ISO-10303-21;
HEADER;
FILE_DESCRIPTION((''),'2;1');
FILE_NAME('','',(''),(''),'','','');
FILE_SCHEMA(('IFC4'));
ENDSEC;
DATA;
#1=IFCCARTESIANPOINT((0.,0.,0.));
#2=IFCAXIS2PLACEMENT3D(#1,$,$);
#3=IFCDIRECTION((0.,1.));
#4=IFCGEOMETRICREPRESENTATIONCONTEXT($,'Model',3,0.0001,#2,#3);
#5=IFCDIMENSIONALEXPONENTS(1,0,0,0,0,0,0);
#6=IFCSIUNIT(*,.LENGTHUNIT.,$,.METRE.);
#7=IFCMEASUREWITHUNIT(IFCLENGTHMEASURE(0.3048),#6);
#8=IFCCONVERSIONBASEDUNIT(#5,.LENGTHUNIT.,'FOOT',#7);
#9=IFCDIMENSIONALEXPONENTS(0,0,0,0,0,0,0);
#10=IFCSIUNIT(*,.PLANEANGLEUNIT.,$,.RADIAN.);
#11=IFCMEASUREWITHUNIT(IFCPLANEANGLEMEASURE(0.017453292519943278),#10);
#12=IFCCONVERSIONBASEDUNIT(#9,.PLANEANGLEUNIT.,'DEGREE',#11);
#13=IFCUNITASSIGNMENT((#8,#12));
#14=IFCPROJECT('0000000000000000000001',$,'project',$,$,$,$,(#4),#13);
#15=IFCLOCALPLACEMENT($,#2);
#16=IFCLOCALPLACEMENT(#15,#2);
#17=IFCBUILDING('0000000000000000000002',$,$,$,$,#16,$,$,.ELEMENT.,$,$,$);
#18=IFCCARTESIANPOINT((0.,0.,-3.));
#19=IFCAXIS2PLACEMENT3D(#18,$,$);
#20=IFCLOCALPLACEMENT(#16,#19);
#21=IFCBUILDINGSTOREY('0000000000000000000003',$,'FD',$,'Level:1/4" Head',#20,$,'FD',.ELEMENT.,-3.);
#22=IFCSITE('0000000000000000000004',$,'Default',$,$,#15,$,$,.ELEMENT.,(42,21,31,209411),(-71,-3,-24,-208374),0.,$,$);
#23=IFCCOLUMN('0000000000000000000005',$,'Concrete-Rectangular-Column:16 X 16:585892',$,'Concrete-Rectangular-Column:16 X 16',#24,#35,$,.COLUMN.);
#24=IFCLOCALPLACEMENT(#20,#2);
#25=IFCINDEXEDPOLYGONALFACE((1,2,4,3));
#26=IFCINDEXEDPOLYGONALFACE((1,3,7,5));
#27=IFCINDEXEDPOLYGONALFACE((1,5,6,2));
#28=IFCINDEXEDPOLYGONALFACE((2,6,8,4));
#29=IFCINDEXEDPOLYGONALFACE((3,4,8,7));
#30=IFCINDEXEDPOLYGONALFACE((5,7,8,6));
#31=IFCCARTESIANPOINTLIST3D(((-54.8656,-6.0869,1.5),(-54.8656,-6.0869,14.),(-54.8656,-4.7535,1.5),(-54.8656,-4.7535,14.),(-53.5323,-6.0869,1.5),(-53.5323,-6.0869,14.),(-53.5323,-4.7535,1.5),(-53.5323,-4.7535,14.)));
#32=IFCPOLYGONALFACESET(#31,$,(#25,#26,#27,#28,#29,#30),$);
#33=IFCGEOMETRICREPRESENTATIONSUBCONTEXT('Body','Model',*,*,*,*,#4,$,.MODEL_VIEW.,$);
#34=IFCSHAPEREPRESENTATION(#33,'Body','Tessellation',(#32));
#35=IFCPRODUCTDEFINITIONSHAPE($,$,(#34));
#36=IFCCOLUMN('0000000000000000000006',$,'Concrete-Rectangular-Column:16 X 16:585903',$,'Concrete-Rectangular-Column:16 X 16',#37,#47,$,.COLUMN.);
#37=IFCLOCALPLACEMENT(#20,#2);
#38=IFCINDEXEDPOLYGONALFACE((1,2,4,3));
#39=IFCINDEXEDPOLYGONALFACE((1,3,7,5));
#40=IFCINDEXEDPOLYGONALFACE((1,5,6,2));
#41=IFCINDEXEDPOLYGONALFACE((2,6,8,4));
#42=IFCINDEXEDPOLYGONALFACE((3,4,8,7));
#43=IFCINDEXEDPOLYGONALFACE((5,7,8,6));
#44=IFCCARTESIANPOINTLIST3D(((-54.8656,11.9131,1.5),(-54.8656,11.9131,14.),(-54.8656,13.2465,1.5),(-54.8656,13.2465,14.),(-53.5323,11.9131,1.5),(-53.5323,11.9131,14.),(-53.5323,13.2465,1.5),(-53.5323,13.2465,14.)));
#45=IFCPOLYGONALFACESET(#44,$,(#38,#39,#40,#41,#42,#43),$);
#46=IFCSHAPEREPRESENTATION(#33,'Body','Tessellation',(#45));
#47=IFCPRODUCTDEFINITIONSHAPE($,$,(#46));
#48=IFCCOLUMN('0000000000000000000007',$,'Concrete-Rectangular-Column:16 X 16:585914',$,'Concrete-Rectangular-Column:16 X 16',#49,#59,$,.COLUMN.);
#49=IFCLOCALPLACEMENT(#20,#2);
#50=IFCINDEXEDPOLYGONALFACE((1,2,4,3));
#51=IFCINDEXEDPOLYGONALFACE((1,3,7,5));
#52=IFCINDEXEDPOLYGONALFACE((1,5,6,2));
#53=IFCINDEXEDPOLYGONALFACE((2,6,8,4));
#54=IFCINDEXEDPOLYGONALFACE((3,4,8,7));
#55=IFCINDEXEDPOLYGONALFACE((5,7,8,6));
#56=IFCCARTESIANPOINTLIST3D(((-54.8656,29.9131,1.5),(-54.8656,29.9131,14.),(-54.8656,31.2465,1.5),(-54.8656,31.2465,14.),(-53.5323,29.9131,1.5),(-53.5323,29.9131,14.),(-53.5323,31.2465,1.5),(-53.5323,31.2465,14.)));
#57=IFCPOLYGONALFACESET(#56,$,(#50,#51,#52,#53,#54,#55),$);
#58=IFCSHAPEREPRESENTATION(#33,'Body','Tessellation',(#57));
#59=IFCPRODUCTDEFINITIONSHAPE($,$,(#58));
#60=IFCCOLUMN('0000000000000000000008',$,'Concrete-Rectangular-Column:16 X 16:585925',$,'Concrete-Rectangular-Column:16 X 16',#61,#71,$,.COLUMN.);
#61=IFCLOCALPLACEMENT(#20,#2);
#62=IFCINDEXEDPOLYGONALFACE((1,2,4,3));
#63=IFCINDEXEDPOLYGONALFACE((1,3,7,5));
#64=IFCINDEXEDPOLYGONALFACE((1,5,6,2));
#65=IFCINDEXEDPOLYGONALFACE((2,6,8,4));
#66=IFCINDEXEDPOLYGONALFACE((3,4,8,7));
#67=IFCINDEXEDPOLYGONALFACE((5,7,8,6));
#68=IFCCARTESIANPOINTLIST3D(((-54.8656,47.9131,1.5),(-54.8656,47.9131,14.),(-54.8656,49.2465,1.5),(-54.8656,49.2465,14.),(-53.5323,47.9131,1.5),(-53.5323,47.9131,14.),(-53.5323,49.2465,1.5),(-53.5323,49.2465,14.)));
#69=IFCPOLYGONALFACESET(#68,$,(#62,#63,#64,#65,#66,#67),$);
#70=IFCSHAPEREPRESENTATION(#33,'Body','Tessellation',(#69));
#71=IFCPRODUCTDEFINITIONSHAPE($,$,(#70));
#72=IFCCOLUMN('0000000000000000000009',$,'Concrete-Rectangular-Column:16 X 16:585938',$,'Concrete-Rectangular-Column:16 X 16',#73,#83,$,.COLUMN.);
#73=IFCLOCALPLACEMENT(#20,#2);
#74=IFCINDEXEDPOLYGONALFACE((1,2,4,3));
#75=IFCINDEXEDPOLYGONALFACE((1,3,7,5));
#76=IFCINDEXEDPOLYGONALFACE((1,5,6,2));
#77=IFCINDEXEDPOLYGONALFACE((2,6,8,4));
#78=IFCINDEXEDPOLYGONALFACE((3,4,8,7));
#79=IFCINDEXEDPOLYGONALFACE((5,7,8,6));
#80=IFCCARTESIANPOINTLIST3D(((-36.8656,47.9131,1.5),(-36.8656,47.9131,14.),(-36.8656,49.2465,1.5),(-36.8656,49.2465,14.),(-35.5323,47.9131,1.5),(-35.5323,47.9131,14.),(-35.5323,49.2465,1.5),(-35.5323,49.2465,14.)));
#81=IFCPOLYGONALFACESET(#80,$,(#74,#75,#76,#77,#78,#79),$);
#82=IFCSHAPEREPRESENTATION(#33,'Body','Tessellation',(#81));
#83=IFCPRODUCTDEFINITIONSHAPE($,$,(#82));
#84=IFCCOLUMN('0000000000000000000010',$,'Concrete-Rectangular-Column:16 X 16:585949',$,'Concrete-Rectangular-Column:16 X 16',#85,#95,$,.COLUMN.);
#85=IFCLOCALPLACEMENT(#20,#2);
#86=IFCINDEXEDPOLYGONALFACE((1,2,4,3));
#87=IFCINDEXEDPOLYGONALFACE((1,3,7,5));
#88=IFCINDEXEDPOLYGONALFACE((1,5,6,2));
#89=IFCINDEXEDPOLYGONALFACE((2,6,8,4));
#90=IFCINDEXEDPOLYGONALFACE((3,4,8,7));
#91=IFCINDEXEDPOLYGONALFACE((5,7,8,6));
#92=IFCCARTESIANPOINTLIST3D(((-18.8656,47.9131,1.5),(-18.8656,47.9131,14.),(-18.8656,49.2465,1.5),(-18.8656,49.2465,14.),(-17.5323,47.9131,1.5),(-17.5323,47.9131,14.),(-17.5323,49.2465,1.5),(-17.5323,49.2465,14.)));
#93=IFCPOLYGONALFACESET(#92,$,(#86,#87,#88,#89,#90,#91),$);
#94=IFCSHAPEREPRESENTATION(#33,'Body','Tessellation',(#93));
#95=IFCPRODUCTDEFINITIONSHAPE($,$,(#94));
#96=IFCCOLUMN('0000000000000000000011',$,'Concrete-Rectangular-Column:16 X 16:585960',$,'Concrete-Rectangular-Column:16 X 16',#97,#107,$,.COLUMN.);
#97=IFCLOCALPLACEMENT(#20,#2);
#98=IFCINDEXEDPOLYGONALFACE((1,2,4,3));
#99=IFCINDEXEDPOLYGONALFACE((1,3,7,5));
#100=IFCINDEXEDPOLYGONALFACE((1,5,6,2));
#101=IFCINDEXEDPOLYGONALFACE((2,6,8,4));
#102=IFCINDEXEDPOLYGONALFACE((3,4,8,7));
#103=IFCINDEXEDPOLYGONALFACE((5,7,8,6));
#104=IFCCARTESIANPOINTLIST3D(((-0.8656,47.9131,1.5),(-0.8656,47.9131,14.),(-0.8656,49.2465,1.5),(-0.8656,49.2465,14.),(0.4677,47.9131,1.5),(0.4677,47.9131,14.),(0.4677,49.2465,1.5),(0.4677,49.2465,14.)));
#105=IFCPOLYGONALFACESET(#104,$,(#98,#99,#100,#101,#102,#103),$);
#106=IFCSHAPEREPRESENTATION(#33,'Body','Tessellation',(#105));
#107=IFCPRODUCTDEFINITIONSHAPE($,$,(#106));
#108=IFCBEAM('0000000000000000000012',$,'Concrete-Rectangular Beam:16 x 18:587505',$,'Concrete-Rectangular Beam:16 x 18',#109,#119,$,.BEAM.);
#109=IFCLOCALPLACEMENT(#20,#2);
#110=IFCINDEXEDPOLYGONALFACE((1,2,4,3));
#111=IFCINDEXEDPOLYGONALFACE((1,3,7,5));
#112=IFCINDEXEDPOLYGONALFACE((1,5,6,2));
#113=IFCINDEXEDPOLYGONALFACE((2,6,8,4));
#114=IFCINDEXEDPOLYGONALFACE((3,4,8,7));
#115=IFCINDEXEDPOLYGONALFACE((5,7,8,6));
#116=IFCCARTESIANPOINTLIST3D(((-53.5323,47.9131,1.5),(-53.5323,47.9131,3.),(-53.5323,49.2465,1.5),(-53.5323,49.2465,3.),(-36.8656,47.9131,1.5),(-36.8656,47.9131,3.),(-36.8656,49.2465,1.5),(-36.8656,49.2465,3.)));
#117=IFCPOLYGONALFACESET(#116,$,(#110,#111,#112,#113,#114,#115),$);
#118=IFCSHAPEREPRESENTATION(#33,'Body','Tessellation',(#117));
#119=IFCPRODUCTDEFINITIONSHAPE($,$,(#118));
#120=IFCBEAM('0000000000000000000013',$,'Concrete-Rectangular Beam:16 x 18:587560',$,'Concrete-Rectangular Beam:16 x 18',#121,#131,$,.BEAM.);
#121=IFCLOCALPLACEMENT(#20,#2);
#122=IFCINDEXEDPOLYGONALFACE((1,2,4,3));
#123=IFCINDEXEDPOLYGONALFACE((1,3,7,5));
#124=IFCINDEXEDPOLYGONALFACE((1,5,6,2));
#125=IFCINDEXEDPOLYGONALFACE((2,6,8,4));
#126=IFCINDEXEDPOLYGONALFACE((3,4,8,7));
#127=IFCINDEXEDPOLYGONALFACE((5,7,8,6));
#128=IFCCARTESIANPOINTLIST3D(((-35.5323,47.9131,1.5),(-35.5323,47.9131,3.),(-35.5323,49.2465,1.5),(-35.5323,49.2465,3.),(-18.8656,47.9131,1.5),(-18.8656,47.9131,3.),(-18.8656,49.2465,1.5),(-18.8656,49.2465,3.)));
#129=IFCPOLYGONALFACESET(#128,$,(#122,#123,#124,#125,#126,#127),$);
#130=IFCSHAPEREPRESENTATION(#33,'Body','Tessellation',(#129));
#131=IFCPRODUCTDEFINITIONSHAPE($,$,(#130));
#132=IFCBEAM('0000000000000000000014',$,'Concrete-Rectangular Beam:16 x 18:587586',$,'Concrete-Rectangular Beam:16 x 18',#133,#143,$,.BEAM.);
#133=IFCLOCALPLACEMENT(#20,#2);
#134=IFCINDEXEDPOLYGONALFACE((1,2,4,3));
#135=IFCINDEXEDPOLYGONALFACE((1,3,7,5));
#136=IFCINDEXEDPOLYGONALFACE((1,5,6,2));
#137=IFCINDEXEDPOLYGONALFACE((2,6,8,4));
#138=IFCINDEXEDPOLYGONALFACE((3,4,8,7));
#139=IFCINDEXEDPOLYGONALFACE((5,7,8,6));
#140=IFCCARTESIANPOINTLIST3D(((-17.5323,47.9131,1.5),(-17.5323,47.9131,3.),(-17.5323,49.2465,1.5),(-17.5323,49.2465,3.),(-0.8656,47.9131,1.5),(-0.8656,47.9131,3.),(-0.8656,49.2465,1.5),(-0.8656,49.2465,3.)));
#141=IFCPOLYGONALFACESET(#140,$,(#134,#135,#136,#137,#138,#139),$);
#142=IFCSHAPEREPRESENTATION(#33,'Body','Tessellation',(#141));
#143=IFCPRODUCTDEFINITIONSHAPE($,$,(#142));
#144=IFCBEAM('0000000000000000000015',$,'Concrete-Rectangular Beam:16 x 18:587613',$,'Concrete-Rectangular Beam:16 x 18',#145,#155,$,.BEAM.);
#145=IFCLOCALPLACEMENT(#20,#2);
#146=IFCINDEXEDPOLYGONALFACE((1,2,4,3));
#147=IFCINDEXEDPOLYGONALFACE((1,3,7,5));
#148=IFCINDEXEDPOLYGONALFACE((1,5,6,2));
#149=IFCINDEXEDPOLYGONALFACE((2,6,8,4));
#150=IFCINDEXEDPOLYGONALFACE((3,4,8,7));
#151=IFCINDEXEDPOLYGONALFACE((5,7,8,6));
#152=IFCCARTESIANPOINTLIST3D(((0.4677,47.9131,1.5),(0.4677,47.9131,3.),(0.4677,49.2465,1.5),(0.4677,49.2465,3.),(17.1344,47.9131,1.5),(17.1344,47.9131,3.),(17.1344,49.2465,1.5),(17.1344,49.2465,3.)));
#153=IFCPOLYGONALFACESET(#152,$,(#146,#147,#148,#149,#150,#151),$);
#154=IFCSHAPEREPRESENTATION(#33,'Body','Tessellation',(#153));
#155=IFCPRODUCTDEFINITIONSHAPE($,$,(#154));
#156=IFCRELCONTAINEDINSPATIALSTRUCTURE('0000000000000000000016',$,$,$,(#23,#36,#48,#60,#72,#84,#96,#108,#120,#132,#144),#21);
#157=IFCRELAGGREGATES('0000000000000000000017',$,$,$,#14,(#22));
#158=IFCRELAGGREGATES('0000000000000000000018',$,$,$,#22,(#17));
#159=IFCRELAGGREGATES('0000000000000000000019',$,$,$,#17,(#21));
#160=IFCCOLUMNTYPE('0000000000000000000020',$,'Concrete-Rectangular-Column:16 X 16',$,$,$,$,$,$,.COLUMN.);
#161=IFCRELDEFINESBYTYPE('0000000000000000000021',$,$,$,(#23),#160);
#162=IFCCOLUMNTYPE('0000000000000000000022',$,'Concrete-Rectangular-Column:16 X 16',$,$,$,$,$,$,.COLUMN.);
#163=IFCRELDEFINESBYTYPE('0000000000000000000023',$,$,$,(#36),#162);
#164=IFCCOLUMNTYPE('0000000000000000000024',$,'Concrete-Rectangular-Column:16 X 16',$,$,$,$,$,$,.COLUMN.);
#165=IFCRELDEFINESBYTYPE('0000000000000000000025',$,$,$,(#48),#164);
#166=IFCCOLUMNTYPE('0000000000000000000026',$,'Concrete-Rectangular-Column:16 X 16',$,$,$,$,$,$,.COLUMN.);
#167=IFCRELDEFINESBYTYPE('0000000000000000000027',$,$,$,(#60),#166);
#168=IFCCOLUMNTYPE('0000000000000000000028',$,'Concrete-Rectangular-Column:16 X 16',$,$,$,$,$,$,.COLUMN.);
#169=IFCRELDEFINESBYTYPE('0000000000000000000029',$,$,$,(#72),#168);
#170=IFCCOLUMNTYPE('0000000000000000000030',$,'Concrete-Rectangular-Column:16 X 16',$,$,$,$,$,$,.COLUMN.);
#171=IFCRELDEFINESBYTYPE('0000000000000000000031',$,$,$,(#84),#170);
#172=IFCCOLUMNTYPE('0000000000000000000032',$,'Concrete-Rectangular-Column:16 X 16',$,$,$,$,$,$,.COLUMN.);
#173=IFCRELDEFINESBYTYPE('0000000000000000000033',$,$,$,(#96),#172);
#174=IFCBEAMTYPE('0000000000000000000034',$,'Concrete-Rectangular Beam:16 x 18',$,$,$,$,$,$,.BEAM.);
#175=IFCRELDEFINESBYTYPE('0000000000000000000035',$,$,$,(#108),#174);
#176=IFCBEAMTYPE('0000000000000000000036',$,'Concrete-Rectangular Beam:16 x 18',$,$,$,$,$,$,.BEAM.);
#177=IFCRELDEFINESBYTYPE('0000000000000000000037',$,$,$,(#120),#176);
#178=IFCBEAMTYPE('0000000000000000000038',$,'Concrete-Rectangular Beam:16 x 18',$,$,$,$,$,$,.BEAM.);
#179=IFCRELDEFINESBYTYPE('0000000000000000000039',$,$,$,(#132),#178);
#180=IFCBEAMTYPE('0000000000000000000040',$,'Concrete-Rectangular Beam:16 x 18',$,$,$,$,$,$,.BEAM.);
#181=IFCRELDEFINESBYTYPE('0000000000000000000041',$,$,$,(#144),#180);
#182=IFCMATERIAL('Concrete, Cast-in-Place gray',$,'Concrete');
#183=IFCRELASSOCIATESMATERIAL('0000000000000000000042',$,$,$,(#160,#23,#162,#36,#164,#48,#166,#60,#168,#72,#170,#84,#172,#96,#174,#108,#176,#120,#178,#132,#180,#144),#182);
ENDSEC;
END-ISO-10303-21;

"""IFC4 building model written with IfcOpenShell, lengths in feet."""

from ifc_helpers import new_model, entity, si_unit, converted_unit, direction, frame, origin, place, context, subcontext, project, spatial, indexed_curve, outline, extrude, source, transform, mapped, material, type_object, type_shapes, element, save


model = new_model("IFC4")

# Units and contexts
model_context = context("Model", 3, precision=0.0001, world=origin(), true_north=direction((0.0, 1.0)))
body_context = subcontext(model_context, "Body", "Model", "MODEL_VIEW")
ifc_project = project(units=[converted_unit("LENGTHUNIT", "FOOT", entity("IfcLengthMeasure", 0.3048), si_unit("LENGTHUNIT", "METRE"), dimensions=[1, 0, 0, 0, 0, 0, 0]), converted_unit("PLANEANGLEUNIT", "DEGREE", entity("IfcPlaneAngleMeasure", 0.017453292519943278), si_unit("PLANEANGLEUNIT", "RADIAN"), dimensions=[0, 0, 0, 0, 0, 0, 0])], contexts=[model_context])

# Site, building, storey
site_placement = place(None, origin())
site = spatial("IfcSite", under=ifc_project, at=site_placement, Name="Default", CompositionType="ELEMENT", RefLatitude=(42, 21, 31, 209411), RefLongitude=(-71, -3, -24, -208374), RefElevation=0.0)
building_placement = place(site_placement, origin())
building = spatial("IfcBuilding", under=site, at=building_placement, CompositionType="ELEMENT")
storey_placement = place(building_placement, frame((0.0, 0.0, -3.0)))
storey = spatial("IfcBuildingStorey", under=building, at=storey_placement, Name="FD", ObjectType="Level:1/4\" Head", LongName="FD", CompositionType="ELEMENT", Elevation=-3.0)

# Columns
ifc_material = material(Name="Concrete, Cast-in-Place gray", Category="Concrete")
column_type_1 = type_object("IfcColumnType", Name="Concrete-Rectangular-Column:16 X 16", PredefinedType="COLUMN", material=ifc_material)
shared_shape_1 = source(origin(), body_context, "Body", "SweptSolid", [
    extrude(outline(indexed_curve([(-6.25, -0.6667), (6.25, -0.6667), (6.25, 0.6667), (-6.25, 0.6667), (-6.25, -0.6667)], self_intersect=False)), frame((-54.8656, -5.4202, 4.75), z_axis=(1.0, 0.0, 0.0), x_axis=(0.0, 0.0, 1.0)), (0.0, 0.0, 1.0), 1.3333),
])
type_shapes(column_type_1, [shared_shape_1])
column_1_placement = place(storey_placement, frame((0.0, 0.0, 3.0)))
element("IfcColumn", 1, at=column_1_placement, inside=storey, type_object=column_type_1, material=ifc_material, Name="Concrete-Rectangular-Column:16 X 16:585892", ObjectType="Concrete-Rectangular-Column:16 X 16", PredefinedType="COLUMN", context=body_context, shape_type="MappedRepresentation", body=[
    mapped(shared_shape_1, transform((0.0, 0.0, 0.0), scale=1.0)),
])
column_type_2 = type_object("IfcColumnType", Name="Concrete-Rectangular-Column:16 X 16", PredefinedType="COLUMN", material=ifc_material)
shared_shape_2 = source(origin(), body_context, "Body", "SweptSolid", [
    extrude(outline(indexed_curve([(-6.25, -0.6667), (6.25, -0.6667), (6.25, 0.6667), (-6.25, 0.6667), (-6.25, -0.6667)], self_intersect=False)), frame((-54.8656, 12.5798, 4.75), z_axis=(1.0, 0.0, 0.0), x_axis=(0.0, 0.0, 1.0)), (0.0, 0.0, 1.0), 1.3333),
])
type_shapes(column_type_2, [shared_shape_2])
column_2_placement = place(storey_placement, frame((0.0, 0.0, 3.0)))
element("IfcColumn", 2, at=column_2_placement, inside=storey, type_object=column_type_2, material=ifc_material, Name="Concrete-Rectangular-Column:16 X 16:585903", ObjectType="Concrete-Rectangular-Column:16 X 16", PredefinedType="COLUMN", context=body_context, shape_type="MappedRepresentation", body=[
    mapped(shared_shape_2, transform((0.0, 0.0, 0.0), scale=1.0)),
])
column_type_3 = type_object("IfcColumnType", Name="Concrete-Rectangular-Column:16 X 16", PredefinedType="COLUMN", material=ifc_material)
shared_shape_3 = source(origin(), body_context, "Body", "SweptSolid", [
    extrude(outline(indexed_curve([(-6.25, -0.6667), (6.25, -0.6667), (6.25, 0.6667), (-6.25, 0.6667), (-6.25, -0.6667)], self_intersect=False)), frame((-54.8656, 30.5798, 4.75), z_axis=(1.0, 0.0, 0.0), x_axis=(0.0, 0.0, 1.0)), (0.0, 0.0, 1.0), 1.3333),
])
type_shapes(column_type_3, [shared_shape_3])
column_3_placement = place(storey_placement, frame((0.0, 0.0, 3.0)))
element("IfcColumn", 3, at=column_3_placement, inside=storey, type_object=column_type_3, material=ifc_material, Name="Concrete-Rectangular-Column:16 X 16:585914", ObjectType="Concrete-Rectangular-Column:16 X 16", PredefinedType="COLUMN", context=body_context, shape_type="MappedRepresentation", body=[
    mapped(shared_shape_3, transform((0.0, 0.0, 0.0), scale=1.0)),
])
column_type_4 = type_object("IfcColumnType", Name="Concrete-Rectangular-Column:16 X 16", PredefinedType="COLUMN", material=ifc_material)
shared_shape_4 = source(origin(), body_context, "Body", "SweptSolid", [
    extrude(outline(indexed_curve([(-6.25, -0.6667), (6.25, -0.6667), (6.25, 0.6667), (-6.25, 0.6667), (-6.25, -0.6667)], self_intersect=False)), frame((-54.8656, 48.5798, 4.75), z_axis=(1.0, 0.0, 0.0), x_axis=(0.0, 0.0, 1.0)), (0.0, 0.0, 1.0), 1.3333),
])
type_shapes(column_type_4, [shared_shape_4])
column_4_placement = place(storey_placement, frame((0.0, 0.0, 3.0)))
element("IfcColumn", 4, at=column_4_placement, inside=storey, type_object=column_type_4, material=ifc_material, Name="Concrete-Rectangular-Column:16 X 16:585925", ObjectType="Concrete-Rectangular-Column:16 X 16", PredefinedType="COLUMN", context=body_context, shape_type="MappedRepresentation", body=[
    mapped(shared_shape_4, transform((0.0, 0.0, 0.0), scale=1.0)),
])
column_type_5 = type_object("IfcColumnType", Name="Concrete-Rectangular-Column:16 X 16", PredefinedType="COLUMN", material=ifc_material)
shared_shape_5 = source(origin(), body_context, "Body", "SweptSolid", [
    extrude(outline(indexed_curve([(-6.25, -0.6667), (6.25, -0.6667), (6.25, 0.6667), (-6.25, 0.6667), (-6.25, -0.6667)], self_intersect=False)), frame((-36.8656, 48.5798, 4.75), z_axis=(1.0, 0.0, 0.0), x_axis=(0.0, 0.0, 1.0)), (0.0, 0.0, 1.0), 1.3333),
])
type_shapes(column_type_5, [shared_shape_5])
column_5_placement = place(storey_placement, frame((0.0, 0.0, 3.0)))
element("IfcColumn", 5, at=column_5_placement, inside=storey, type_object=column_type_5, material=ifc_material, Name="Concrete-Rectangular-Column:16 X 16:585938", ObjectType="Concrete-Rectangular-Column:16 X 16", PredefinedType="COLUMN", context=body_context, shape_type="MappedRepresentation", body=[
    mapped(shared_shape_5, transform((0.0, 0.0, 0.0), scale=1.0)),
])
column_type_6 = type_object("IfcColumnType", Name="Concrete-Rectangular-Column:16 X 16", PredefinedType="COLUMN", material=ifc_material)
shared_shape_6 = source(origin(), body_context, "Body", "SweptSolid", [
    extrude(outline(indexed_curve([(-6.25, -0.6667), (6.25, -0.6667), (6.25, 0.6667), (-6.25, 0.6667), (-6.25, -0.6667)], self_intersect=False)), frame((-18.8656, 48.5798, 4.75), z_axis=(1.0, 0.0, 0.0), x_axis=(0.0, 0.0, 1.0)), (0.0, 0.0, 1.0), 1.3333),
])
type_shapes(column_type_6, [shared_shape_6])
column_6_placement = place(storey_placement, frame((0.0, 0.0, 3.0)))
element("IfcColumn", 6, at=column_6_placement, inside=storey, type_object=column_type_6, material=ifc_material, Name="Concrete-Rectangular-Column:16 X 16:585949", ObjectType="Concrete-Rectangular-Column:16 X 16", PredefinedType="COLUMN", context=body_context, shape_type="MappedRepresentation", body=[
    mapped(shared_shape_6, transform((0.0, 0.0, 0.0), scale=1.0)),
])
column_type_7 = type_object("IfcColumnType", Name="Concrete-Rectangular-Column:16 X 16", PredefinedType="COLUMN", material=ifc_material)
shared_shape_7 = source(origin(), body_context, "Body", "SweptSolid", [
    extrude(outline(indexed_curve([(-6.25, -0.6667), (6.25, -0.6667), (6.25, 0.6667), (-6.25, 0.6667), (-6.25, -0.6667)], self_intersect=False)), frame((-0.8656, 48.5798, 4.75), z_axis=(1.0, 0.0, 0.0), x_axis=(0.0, 0.0, 1.0)), (0.0, 0.0, 1.0), 1.3333),
])
type_shapes(column_type_7, [shared_shape_7])
column_7_placement = place(storey_placement, frame((0.0, 0.0, 3.0)))
element("IfcColumn", 7, at=column_7_placement, inside=storey, type_object=column_type_7, material=ifc_material, Name="Concrete-Rectangular-Column:16 X 16:585960", ObjectType="Concrete-Rectangular-Column:16 X 16", PredefinedType="COLUMN", context=body_context, shape_type="MappedRepresentation", body=[
    mapped(shared_shape_7, transform((0.0, 0.0, 0.0), scale=1.0)),
])

# Beams
beam_type_1 = type_object("IfcBeamType", Name="Concrete-Rectangular Beam:16 x 18", PredefinedType="BEAM", material=ifc_material)
shared_shape_8 = source(origin(), body_context, "Body", "SweptSolid", [
    extrude(outline(indexed_curve([(-0.75, -0.6667), (0.75, -0.6667), (0.75, 0.6667), (-0.75, 0.6667), (-0.75, -0.6667)], self_intersect=False)), frame((-53.5323, 48.5798, -0.75), z_axis=(1.0, 0.0, 0.0), x_axis=(0.0, 0.0, -1.0)), (0.0, 0.0, 1.0), 16.6667),
])
type_shapes(beam_type_1, [shared_shape_8])
beam_1_placement = place(storey_placement, frame((0.0, 0.0, 3.0)))
element("IfcBeam", 8, at=beam_1_placement, inside=storey, type_object=beam_type_1, material=ifc_material, Name="Concrete-Rectangular Beam:16 x 18:587505", ObjectType="Concrete-Rectangular Beam:16 x 18", PredefinedType="BEAM", context=body_context, shape_type="MappedRepresentation", body=[
    mapped(shared_shape_8, transform((0.0, 0.0, 0.0), scale=1.0)),
])
beam_type_2 = type_object("IfcBeamType", Name="Concrete-Rectangular Beam:16 x 18", PredefinedType="BEAM", material=ifc_material)
shared_shape_9 = source(origin(), body_context, "Body", "SweptSolid", [
    extrude(outline(indexed_curve([(-0.75, -0.6667), (0.75, -0.6667), (0.75, 0.6667), (-0.75, 0.6667), (-0.75, -0.6667)], self_intersect=False)), frame((-18.8656, 48.5798, -0.75), z_axis=(-1.0, 0.0, 0.0), x_axis=(0.0, 0.0, -1.0)), (0.0, 0.0, 1.0), 16.6667),
])
type_shapes(beam_type_2, [shared_shape_9])
beam_2_placement = place(storey_placement, frame((0.0, 0.0, 3.0)))
element("IfcBeam", 9, at=beam_2_placement, inside=storey, type_object=beam_type_2, material=ifc_material, Name="Concrete-Rectangular Beam:16 x 18:587560", ObjectType="Concrete-Rectangular Beam:16 x 18", PredefinedType="BEAM", context=body_context, shape_type="MappedRepresentation", body=[
    mapped(shared_shape_9, transform((0.0, 0.0, 0.0), scale=1.0)),
])
beam_type_3 = type_object("IfcBeamType", Name="Concrete-Rectangular Beam:16 x 18", PredefinedType="BEAM", material=ifc_material)
shared_shape_10 = source(origin(), body_context, "Body", "SweptSolid", [
    extrude(outline(indexed_curve([(-0.75, -0.6667), (0.75, -0.6667), (0.75, 0.6667), (-0.75, 0.6667), (-0.75, -0.6667)], self_intersect=False)), frame((-17.5323, 48.5798, -0.75), z_axis=(1.0, 0.0, 0.0), x_axis=(0.0, 0.0, -1.0)), (0.0, 0.0, 1.0), 16.6667),
])
type_shapes(beam_type_3, [shared_shape_10])
beam_3_placement = place(storey_placement, frame((0.0, 0.0, 3.0)))
element("IfcBeam", 10, at=beam_3_placement, inside=storey, type_object=beam_type_3, material=ifc_material, Name="Concrete-Rectangular Beam:16 x 18:587586", ObjectType="Concrete-Rectangular Beam:16 x 18", PredefinedType="BEAM", context=body_context, shape_type="MappedRepresentation", body=[
    mapped(shared_shape_10, transform((0.0, 0.0, 0.0), scale=1.0)),
])
beam_type_4 = type_object("IfcBeamType", Name="Concrete-Rectangular Beam:16 x 18", PredefinedType="BEAM", material=ifc_material)
shared_shape_11 = source(origin(), body_context, "Body", "SweptSolid", [
    extrude(outline(indexed_curve([(-0.75, -0.6667), (0.75, -0.6667), (0.75, 0.6667), (-0.75, 0.6667), (-0.75, -0.6667)], self_intersect=False)), frame((0.4677, 48.5798, -0.75), z_axis=(1.0, 0.0, 0.0), x_axis=(0.0, 0.0, -1.0)), (0.0, 0.0, 1.0), 16.6667),
])
type_shapes(beam_type_4, [shared_shape_11])
beam_4_placement = place(storey_placement, frame((0.0, 0.0, 3.0)))
element("IfcBeam", 11, at=beam_4_placement, inside=storey, type_object=beam_type_4, material=ifc_material, Name="Concrete-Rectangular Beam:16 x 18:587613", ObjectType="Concrete-Rectangular Beam:16 x 18", PredefinedType="BEAM", context=body_context, shape_type="MappedRepresentation", body=[
    mapped(shared_shape_11, transform((0.0, 0.0, 0.0), scale=1.0)),
])

save(model, "model.ifc")
